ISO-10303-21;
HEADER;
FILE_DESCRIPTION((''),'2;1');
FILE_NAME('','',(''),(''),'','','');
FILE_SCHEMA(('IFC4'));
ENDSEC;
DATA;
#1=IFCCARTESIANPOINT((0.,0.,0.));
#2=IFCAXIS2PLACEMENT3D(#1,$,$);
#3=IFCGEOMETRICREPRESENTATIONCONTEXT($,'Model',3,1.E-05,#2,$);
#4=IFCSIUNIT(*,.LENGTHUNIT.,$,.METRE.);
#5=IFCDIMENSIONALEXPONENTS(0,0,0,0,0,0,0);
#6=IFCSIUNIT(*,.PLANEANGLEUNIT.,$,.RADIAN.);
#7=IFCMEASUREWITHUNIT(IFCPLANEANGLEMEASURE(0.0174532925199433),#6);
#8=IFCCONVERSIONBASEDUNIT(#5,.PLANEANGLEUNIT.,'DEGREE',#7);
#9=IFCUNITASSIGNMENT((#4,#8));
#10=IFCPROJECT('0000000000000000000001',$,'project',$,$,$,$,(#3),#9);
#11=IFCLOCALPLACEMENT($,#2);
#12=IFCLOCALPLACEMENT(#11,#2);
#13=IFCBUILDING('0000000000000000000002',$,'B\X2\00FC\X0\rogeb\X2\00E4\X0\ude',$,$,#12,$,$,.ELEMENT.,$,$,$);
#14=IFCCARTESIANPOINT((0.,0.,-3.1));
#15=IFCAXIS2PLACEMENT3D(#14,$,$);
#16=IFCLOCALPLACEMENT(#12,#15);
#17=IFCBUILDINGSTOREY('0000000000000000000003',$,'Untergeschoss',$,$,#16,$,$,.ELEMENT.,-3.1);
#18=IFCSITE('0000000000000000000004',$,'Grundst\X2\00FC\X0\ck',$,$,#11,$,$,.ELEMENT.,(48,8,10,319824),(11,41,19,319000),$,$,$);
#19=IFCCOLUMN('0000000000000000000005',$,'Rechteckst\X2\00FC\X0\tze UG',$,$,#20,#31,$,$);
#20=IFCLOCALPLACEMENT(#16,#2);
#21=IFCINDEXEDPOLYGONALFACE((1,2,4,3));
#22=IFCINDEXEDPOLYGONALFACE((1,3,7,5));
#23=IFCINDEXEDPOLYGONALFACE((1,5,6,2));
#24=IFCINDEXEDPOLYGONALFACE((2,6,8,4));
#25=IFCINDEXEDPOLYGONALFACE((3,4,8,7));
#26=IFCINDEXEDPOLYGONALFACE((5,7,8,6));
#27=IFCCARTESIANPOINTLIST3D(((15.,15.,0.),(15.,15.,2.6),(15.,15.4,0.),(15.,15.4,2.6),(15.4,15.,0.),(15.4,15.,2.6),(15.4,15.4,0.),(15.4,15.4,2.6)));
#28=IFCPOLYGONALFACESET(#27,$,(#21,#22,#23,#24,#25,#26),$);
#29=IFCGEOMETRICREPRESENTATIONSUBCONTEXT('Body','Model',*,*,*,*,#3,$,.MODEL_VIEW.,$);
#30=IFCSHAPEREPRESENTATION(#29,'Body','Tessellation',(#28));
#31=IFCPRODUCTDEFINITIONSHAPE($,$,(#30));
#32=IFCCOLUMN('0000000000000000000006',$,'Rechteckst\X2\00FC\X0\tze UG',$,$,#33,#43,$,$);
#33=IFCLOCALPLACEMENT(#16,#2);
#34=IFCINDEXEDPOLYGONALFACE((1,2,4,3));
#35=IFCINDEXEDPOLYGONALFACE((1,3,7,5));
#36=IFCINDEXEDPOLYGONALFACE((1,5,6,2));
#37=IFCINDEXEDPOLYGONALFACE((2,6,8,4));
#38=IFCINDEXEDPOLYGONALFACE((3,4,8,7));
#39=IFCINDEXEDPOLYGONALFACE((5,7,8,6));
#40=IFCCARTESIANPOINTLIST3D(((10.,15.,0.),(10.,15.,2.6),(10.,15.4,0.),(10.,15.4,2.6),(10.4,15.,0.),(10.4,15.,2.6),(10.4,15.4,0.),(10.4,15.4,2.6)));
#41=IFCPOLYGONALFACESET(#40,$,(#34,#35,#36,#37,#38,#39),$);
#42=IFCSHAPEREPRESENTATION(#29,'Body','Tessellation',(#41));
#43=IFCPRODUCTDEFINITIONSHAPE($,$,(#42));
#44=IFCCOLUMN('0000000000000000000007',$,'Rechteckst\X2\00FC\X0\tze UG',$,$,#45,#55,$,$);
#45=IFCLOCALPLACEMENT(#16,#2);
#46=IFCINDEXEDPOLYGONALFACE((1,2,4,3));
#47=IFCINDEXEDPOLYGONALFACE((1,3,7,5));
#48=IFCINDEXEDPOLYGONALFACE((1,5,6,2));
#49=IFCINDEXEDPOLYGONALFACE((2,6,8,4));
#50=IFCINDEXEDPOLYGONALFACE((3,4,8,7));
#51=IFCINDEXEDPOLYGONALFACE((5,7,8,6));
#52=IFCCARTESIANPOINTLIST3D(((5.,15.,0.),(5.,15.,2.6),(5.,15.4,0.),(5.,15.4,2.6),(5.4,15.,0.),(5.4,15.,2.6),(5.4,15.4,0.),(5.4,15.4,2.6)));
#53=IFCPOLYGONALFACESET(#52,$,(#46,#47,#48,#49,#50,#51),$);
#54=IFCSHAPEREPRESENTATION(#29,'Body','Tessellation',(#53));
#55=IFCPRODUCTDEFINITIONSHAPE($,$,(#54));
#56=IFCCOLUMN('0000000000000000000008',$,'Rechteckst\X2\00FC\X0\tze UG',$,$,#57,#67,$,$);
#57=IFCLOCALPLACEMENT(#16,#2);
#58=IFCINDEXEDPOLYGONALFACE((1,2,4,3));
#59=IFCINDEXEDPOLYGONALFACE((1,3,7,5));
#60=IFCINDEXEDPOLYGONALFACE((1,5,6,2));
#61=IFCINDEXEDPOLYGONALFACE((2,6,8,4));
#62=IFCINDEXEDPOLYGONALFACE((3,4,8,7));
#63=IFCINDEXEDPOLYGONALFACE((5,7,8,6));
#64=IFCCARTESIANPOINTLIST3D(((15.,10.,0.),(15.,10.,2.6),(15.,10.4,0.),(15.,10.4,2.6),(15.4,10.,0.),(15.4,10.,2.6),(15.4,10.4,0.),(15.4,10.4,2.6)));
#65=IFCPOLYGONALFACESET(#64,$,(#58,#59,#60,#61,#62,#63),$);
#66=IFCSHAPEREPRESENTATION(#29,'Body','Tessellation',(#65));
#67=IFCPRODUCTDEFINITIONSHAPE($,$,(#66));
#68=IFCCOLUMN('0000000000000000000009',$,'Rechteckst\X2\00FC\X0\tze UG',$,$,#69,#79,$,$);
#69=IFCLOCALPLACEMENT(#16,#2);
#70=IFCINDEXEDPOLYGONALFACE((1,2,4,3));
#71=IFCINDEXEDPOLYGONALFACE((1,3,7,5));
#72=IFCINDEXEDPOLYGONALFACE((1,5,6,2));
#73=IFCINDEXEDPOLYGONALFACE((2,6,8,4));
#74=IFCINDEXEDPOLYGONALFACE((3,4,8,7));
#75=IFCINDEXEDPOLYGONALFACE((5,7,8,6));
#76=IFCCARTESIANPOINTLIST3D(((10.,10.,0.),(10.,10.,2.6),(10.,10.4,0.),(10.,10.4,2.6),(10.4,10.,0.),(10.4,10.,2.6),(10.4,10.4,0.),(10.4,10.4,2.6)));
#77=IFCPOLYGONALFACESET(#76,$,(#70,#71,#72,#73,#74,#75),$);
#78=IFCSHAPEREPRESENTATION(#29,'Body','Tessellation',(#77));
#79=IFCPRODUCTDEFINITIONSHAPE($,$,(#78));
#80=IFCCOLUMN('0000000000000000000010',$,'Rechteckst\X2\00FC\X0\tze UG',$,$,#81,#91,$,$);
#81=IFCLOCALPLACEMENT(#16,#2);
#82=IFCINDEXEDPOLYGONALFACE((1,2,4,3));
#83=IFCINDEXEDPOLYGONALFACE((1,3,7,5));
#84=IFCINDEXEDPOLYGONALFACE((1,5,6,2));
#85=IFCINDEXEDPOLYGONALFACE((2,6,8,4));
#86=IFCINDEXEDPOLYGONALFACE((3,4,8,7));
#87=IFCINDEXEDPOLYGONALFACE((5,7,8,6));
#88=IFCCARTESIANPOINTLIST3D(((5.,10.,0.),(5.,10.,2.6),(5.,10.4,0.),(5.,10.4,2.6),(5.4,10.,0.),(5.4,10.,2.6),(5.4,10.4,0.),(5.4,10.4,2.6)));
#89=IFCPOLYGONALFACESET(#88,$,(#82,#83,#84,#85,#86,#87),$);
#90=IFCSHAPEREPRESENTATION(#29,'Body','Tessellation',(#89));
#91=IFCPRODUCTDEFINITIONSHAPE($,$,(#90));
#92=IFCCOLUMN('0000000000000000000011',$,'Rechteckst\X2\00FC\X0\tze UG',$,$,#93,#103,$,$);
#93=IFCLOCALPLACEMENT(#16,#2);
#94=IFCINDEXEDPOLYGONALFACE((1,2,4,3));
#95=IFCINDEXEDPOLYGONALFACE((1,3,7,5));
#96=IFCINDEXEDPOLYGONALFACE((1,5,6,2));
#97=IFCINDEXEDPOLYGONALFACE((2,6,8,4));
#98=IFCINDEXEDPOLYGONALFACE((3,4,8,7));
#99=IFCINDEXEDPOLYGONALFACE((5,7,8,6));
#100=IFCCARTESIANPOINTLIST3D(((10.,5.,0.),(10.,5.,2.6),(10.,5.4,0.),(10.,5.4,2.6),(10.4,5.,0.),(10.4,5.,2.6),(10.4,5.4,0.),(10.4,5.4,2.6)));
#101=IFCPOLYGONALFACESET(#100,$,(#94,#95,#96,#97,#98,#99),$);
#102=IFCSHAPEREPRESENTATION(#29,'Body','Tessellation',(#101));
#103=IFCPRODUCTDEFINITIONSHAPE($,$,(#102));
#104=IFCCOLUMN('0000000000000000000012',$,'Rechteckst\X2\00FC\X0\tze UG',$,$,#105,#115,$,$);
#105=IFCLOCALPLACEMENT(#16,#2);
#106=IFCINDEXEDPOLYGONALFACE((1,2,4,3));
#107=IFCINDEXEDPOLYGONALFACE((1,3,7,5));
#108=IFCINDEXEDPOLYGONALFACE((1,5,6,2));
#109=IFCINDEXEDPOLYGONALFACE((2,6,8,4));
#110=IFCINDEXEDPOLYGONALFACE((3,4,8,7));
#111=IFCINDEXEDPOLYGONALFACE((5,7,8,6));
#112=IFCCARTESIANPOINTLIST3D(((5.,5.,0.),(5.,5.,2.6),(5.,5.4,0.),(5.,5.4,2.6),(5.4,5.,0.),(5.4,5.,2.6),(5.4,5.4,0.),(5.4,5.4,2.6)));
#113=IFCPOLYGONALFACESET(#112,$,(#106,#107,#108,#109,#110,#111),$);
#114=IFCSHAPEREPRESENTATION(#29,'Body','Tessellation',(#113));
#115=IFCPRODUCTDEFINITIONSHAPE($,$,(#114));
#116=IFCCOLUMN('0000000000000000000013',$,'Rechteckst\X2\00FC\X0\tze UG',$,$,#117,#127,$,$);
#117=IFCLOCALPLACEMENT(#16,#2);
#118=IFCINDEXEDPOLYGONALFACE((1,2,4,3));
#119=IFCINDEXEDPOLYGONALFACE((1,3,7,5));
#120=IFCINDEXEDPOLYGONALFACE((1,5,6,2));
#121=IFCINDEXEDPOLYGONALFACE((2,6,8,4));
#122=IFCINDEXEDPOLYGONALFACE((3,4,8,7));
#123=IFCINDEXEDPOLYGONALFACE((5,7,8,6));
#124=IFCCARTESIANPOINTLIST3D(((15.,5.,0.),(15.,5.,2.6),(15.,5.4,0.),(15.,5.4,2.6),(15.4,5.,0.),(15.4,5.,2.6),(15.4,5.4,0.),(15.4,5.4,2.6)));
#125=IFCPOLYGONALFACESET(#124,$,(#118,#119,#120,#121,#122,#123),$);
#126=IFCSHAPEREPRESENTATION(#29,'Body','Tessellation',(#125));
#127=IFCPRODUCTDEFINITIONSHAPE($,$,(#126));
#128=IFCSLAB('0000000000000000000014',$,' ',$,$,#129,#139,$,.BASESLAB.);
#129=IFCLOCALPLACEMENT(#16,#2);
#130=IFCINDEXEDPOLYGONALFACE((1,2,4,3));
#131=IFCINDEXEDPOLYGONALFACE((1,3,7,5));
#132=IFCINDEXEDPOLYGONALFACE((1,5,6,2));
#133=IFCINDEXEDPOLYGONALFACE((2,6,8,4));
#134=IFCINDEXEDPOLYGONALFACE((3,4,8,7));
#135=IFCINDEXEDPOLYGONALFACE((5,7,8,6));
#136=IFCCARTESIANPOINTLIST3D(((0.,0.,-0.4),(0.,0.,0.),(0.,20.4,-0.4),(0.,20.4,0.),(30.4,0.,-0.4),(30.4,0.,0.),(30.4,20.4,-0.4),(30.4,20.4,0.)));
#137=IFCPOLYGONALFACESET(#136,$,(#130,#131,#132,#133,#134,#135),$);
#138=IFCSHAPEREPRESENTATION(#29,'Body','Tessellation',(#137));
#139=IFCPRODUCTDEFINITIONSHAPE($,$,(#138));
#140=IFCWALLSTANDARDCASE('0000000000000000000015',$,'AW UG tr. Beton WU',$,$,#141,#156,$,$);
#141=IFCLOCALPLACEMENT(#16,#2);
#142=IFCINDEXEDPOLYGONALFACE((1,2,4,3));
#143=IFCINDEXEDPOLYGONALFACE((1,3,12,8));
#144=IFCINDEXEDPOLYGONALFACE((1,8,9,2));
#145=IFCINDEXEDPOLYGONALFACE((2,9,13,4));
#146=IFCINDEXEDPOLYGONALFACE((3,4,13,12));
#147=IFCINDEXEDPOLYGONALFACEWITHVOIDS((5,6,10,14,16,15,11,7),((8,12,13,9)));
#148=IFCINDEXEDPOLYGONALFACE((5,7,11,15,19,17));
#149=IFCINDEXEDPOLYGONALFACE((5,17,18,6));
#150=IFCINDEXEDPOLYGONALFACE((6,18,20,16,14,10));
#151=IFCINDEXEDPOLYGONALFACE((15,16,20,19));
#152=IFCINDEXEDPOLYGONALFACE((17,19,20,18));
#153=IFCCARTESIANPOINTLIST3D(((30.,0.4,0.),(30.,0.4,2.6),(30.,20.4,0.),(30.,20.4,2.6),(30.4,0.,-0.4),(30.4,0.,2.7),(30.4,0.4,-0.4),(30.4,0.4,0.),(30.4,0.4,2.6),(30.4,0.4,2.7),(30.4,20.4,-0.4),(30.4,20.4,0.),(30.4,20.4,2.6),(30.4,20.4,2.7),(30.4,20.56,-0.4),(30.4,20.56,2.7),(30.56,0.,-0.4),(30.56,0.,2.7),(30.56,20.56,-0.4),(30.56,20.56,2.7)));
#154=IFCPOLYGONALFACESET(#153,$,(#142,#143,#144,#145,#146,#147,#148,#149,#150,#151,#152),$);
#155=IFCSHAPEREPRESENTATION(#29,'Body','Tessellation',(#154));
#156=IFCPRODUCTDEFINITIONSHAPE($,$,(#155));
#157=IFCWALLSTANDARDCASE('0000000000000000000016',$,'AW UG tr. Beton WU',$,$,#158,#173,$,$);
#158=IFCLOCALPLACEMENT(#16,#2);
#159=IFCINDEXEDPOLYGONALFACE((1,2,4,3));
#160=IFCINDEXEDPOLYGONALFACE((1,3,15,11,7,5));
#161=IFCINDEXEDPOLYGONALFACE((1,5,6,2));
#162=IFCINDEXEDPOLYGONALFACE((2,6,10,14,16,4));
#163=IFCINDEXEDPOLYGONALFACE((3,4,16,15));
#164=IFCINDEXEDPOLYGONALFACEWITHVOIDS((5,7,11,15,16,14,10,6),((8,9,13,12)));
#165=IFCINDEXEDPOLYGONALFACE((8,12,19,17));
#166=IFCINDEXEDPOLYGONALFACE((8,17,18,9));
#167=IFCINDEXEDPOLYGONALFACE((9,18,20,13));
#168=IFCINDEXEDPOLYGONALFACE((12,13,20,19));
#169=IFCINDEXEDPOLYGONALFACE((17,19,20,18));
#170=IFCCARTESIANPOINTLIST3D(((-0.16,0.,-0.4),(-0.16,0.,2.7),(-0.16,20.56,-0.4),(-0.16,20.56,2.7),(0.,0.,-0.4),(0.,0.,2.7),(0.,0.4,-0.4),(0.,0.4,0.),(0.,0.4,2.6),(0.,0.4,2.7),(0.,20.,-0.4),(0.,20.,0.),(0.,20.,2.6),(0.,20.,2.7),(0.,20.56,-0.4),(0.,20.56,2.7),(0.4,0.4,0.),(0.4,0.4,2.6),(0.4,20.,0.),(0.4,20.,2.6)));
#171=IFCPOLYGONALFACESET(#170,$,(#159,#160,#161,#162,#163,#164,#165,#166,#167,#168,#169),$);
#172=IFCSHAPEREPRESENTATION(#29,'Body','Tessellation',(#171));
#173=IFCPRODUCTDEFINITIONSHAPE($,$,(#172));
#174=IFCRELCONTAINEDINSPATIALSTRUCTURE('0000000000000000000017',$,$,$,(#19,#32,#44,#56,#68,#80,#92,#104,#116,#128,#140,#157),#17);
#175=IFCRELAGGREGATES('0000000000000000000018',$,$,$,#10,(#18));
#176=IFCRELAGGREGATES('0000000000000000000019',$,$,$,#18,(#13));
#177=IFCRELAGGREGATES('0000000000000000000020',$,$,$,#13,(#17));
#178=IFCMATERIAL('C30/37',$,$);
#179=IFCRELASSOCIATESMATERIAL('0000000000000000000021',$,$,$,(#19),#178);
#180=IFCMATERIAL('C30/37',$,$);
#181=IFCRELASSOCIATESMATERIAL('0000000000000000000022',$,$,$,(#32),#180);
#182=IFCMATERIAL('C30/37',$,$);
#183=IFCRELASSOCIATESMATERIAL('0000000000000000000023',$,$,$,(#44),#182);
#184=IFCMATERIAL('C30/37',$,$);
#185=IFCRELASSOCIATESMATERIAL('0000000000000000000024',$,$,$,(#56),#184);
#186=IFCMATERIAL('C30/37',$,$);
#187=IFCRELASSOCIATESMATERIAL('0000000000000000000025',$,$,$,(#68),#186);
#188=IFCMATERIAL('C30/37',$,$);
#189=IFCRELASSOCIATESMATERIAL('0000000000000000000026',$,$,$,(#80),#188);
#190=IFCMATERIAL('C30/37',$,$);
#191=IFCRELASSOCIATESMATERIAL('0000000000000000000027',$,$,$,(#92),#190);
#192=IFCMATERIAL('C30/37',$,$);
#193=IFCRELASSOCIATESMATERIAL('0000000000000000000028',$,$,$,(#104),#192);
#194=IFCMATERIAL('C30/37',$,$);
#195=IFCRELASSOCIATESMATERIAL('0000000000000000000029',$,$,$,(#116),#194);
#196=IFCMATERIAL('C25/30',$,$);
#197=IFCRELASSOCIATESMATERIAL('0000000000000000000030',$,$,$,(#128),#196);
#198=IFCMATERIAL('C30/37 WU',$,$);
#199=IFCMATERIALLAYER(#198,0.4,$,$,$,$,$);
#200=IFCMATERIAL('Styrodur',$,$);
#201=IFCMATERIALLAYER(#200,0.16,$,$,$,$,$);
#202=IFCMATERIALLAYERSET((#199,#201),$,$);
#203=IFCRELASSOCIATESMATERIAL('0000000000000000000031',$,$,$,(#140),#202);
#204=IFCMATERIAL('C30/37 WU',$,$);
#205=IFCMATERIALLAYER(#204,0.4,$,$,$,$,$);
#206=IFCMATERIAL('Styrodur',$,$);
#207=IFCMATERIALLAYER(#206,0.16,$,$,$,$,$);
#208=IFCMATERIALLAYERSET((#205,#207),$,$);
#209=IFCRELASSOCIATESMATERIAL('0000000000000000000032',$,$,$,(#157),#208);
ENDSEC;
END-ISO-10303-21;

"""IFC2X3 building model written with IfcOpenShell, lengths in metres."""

from ifc_helpers import new_model, entity, si_unit, converted_unit, frame, frame_2d, origin, origin_with_axes, place, context, subcontext, project, spatial, polyline, rectangle, outline, extrude, clip, bounded_halfspace, material, layer, layer_set, layer_usage, element, save


model = new_model("IFC2X3")

# Units and contexts
model_context = context("Model", 3, precision=1e-05, world=origin())
body_context = subcontext(model_context, "Body", "Model", "MODEL_VIEW")
ifc_project = project(units=[si_unit("LENGTHUNIT", "METRE"), converted_unit("PLANEANGLEUNIT", "DEGREE", entity("IfcPlaneAngleMeasure", 0.0174532925199433), si_unit("PLANEANGLEUNIT", "RADIAN"), dimensions=[0, 0, 0, 0, 0, 0, 0])], contexts=[model_context])

# Site, building, storey
site_placement = place(None, origin())
site = spatial("IfcSite", under=ifc_project, at=site_placement, Name="Grundstück", CompositionType="ELEMENT", RefLatitude=(48, 8, 10, 319824), RefLongitude=(11, 41, 19, 319000))
building_placement = place(site_placement, origin())
building = spatial("IfcBuilding", under=site, at=building_placement, Name="Bürogebäude", CompositionType="ELEMENT")
storey_placement = place(building_placement, frame((0.0, 0.0, -3.1)))
storey = spatial("IfcBuildingStorey", under=building, at=storey_placement, Name="Untergeschoss", CompositionType="ELEMENT", Elevation=-3.1)

# Columns
ifc_material_1 = material(Name="C30/37")
column_1_placement = place(storey_placement, frame((15.0, 15.0, 0.0)))
element("IfcColumn", 1, at=column_1_placement, inside=storey, material=ifc_material_1, Name="Rechteckstütze UG", context=body_context, shape_type="SweptSolid", body=[
    extrude(rectangle(XDim=0.4, YDim=0.4, at=frame_2d((0.2, 0.2), x_axis=(1.0, 0.0))), origin_with_axes(), (0.0, 0.0, 1.0), 2.6),
])
ifc_material_2 = material(Name="C30/37")
column_2_placement = place(storey_placement, frame((10.0, 15.0, 0.0)))
element("IfcColumn", 2, at=column_2_placement, inside=storey, material=ifc_material_2, Name="Rechteckstütze UG", context=body_context, shape_type="SweptSolid", body=[
    extrude(rectangle(XDim=0.4, YDim=0.4, at=frame_2d((0.2, 0.2), x_axis=(1.0, 0.0))), origin_with_axes(), (0.0, 0.0, 1.0), 2.6),
])
ifc_material_3 = material(Name="C30/37")
column_3_placement = place(storey_placement, frame((5.0, 15.0, 0.0)))
element("IfcColumn", 3, at=column_3_placement, inside=storey, material=ifc_material_3, Name="Rechteckstütze UG", context=body_context, shape_type="SweptSolid", body=[
    extrude(rectangle(XDim=0.4, YDim=0.4, at=frame_2d((0.2, 0.2), x_axis=(1.0, 0.0))), origin_with_axes(), (0.0, 0.0, 1.0), 2.6),
])
ifc_material_4 = material(Name="C30/37")
column_4_placement = place(storey_placement, frame((15.0, 10.0, 0.0)))
element("IfcColumn", 4, at=column_4_placement, inside=storey, material=ifc_material_4, Name="Rechteckstütze UG", context=body_context, shape_type="SweptSolid", body=[
    extrude(rectangle(XDim=0.4, YDim=0.4, at=frame_2d((0.2, 0.2), x_axis=(1.0, 0.0))), origin_with_axes(), (0.0, 0.0, 1.0), 2.6),
])
ifc_material_5 = material(Name="C30/37")
column_5_placement = place(storey_placement, frame((10.0, 10.0, 0.0)))
element("IfcColumn", 5, at=column_5_placement, inside=storey, material=ifc_material_5, Name="Rechteckstütze UG", context=body_context, shape_type="SweptSolid", body=[
    extrude(rectangle(XDim=0.4, YDim=0.4, at=frame_2d((0.2, 0.2), x_axis=(1.0, 0.0))), origin_with_axes(), (0.0, 0.0, 1.0), 2.6),
])
ifc_material_6 = material(Name="C30/37")
column_6_placement = place(storey_placement, frame((5.0, 10.0, 0.0)))
element("IfcColumn", 6, at=column_6_placement, inside=storey, material=ifc_material_6, Name="Rechteckstütze UG", context=body_context, shape_type="SweptSolid", body=[
    extrude(rectangle(XDim=0.4, YDim=0.4, at=frame_2d((0.2, 0.2), x_axis=(1.0, 0.0))), origin_with_axes(), (0.0, 0.0, 1.0), 2.6),
])
ifc_material_7 = material(Name="C30/37")
column_7_placement = place(storey_placement, frame((10.0, 5.0, 0.0)))
element("IfcColumn", 7, at=column_7_placement, inside=storey, material=ifc_material_7, Name="Rechteckstütze UG", context=body_context, shape_type="SweptSolid", body=[
    extrude(rectangle(XDim=0.4, YDim=0.4, at=frame_2d((0.2, 0.2), x_axis=(1.0, 0.0))), origin_with_axes(), (0.0, 0.0, 1.0), 2.6),
])
ifc_material_8 = material(Name="C30/37")
column_8_placement = place(storey_placement, frame((5.0, 5.0, 0.0)))
element("IfcColumn", 8, at=column_8_placement, inside=storey, material=ifc_material_8, Name="Rechteckstütze UG", context=body_context, shape_type="SweptSolid", body=[
    extrude(rectangle(XDim=0.4, YDim=0.4, at=frame_2d((0.2, 0.2), x_axis=(1.0, 0.0))), origin_with_axes(), (0.0, 0.0, 1.0), 2.6),
])
ifc_material_9 = material(Name="C30/37")
column_9_placement = place(storey_placement, frame((15.0, 5.0, 0.0)))
element("IfcColumn", 9, at=column_9_placement, inside=storey, material=ifc_material_9, Name="Rechteckstütze UG", context=body_context, shape_type="SweptSolid", body=[
    extrude(rectangle(XDim=0.4, YDim=0.4, at=frame_2d((0.2, 0.2), x_axis=(1.0, 0.0))), origin_with_axes(), (0.0, 0.0, 1.0), 2.6),
])

# Slab
ifc_material_10 = material(Name="C25/30")
slab_placement = place(storey_placement, frame((0.0, 0.0, -0.4)))
element("IfcSlab", 10, at=slab_placement, inside=storey, material=ifc_material_10, Name=" ", PredefinedType="BASESLAB", context=body_context, shape_type="SweptSolid", body=[
    extrude(rectangle(XDim=30.4, YDim=20.4, at=frame_2d((15.2, 10.2), x_axis=(1.0, 0.0))), origin_with_axes(), (0.0, 0.0, 1.0), 0.4),
])

# Walls
ifc_material_11 = material(Name="C30/37 WU")
ifc_layer_1 = layer(ifc_material_11, 0.4)
ifc_material_12 = material(Name="Styrodur")
ifc_layer_2 = layer(ifc_material_12, 0.16)
ifc_layer_set_1 = layer_set([ifc_layer_1, ifc_layer_2])
ifc_layer_usage_1 = layer_usage(ifc_layer_set_1, "AXIS2", "POSITIVE", 0.0)
wall_1_placement = place(storey_placement, frame((30.0, 20.4, -0.4), z_axis=(0.0, 0.0, 1.0), x_axis=(0.0, -1.0, 0.0)))
element("IfcWallStandardCase", 11, at=wall_1_placement, inside=storey, material=ifc_layer_usage_1, Name="AW UG tr. Beton WU", context=body_context, shape_type="Clipping", body=[
    clip(clip(extrude(outline(polyline([(-20.4, 0.0), (-0.4, 0.0), (-0.4, 0.4), (0.0, 0.4), (0.0, 0.56), (-20.56, 0.56), (-20.56, 0.4), (-20.4, 0.4), (-20.4, 0.0)])), frame((20.4, 0.0, 0.0), z_axis=(0.0, 0.0, 1.0), x_axis=(1.0, 0.0, 0.0)), (0.0, 0.0, 1.0), 3.1), bounded_halfspace(frame((10.0, 0.2, 0.4), z_axis=(0.0, 0.0, 1.0), x_axis=(0.0, -1.0, 0.0)), True, origin_with_axes(), polyline([(0.0, 0.4), (0.0, 0.0), (20.0, 0.0), (20.0, 0.4), (0.0, 0.4)]))), bounded_halfspace(frame((10.0, 0.2, 3.0), z_axis=(0.0, 0.0, -1.0), x_axis=(1.0, 0.0, 0.0)), True, origin_with_axes(), polyline([(0.0, 0.0), (20.0, 0.0), (20.0, 0.4), (0.0, 0.4), (0.0, 0.0)]))),
])
ifc_material_13 = material(Name="C30/37 WU")
ifc_layer_3 = layer(ifc_material_13, 0.4)
ifc_material_14 = material(Name="Styrodur")
ifc_layer_4 = layer(ifc_material_14, 0.16)
ifc_layer_set_2 = layer_set([ifc_layer_3, ifc_layer_4])
ifc_layer_usage_2 = layer_usage(ifc_layer_set_2, "AXIS2", "POSITIVE", 0.0)
wall_2_placement = place(storey_placement, frame((0.4, 0.4, -0.4), z_axis=(0.0, 0.0, 1.0), x_axis=(0.0, 1.0, 0.0)))
element("IfcWallStandardCase", 12, at=wall_2_placement, inside=storey, material=ifc_layer_usage_2, Name="AW UG tr. Beton WU", context=body_context, shape_type="Clipping", body=[
    clip(clip(extrude(outline(polyline([(0.4, -0.56), (20.0, -0.56), (20.0, -0.16), (20.56, -0.16), (20.56, 0.0), (0.0, 0.0), (0.0, -0.16), (0.4, -0.16), (0.4, -0.56)])), frame((-0.4, 0.56, 0.0), z_axis=(0.0, 0.0, 1.0), x_axis=(1.0, 0.0, 0.0)), (0.0, 0.0, 1.0), 3.1), bounded_halfspace(frame((9.8, 0.2, 0.4), z_axis=(0.0, 0.0, 1.0), x_axis=(0.0, -1.0, 0.0)), True, origin_with_axes(), polyline([(0.0, 0.4), (0.0, 0.0), (19.6, 0.0), (19.6, 0.4), (0.0, 0.4)]))), bounded_halfspace(frame((9.8, 0.2, 3.0), z_axis=(0.0, 0.0, -1.0), x_axis=(1.0, 0.0, 0.0)), True, origin_with_axes(), polyline([(0.0, 0.0), (19.6, 0.0), (19.6, 0.4), (0.0, 0.4), (0.0, 0.0)]))),
])

save(model, "model.ifc")
